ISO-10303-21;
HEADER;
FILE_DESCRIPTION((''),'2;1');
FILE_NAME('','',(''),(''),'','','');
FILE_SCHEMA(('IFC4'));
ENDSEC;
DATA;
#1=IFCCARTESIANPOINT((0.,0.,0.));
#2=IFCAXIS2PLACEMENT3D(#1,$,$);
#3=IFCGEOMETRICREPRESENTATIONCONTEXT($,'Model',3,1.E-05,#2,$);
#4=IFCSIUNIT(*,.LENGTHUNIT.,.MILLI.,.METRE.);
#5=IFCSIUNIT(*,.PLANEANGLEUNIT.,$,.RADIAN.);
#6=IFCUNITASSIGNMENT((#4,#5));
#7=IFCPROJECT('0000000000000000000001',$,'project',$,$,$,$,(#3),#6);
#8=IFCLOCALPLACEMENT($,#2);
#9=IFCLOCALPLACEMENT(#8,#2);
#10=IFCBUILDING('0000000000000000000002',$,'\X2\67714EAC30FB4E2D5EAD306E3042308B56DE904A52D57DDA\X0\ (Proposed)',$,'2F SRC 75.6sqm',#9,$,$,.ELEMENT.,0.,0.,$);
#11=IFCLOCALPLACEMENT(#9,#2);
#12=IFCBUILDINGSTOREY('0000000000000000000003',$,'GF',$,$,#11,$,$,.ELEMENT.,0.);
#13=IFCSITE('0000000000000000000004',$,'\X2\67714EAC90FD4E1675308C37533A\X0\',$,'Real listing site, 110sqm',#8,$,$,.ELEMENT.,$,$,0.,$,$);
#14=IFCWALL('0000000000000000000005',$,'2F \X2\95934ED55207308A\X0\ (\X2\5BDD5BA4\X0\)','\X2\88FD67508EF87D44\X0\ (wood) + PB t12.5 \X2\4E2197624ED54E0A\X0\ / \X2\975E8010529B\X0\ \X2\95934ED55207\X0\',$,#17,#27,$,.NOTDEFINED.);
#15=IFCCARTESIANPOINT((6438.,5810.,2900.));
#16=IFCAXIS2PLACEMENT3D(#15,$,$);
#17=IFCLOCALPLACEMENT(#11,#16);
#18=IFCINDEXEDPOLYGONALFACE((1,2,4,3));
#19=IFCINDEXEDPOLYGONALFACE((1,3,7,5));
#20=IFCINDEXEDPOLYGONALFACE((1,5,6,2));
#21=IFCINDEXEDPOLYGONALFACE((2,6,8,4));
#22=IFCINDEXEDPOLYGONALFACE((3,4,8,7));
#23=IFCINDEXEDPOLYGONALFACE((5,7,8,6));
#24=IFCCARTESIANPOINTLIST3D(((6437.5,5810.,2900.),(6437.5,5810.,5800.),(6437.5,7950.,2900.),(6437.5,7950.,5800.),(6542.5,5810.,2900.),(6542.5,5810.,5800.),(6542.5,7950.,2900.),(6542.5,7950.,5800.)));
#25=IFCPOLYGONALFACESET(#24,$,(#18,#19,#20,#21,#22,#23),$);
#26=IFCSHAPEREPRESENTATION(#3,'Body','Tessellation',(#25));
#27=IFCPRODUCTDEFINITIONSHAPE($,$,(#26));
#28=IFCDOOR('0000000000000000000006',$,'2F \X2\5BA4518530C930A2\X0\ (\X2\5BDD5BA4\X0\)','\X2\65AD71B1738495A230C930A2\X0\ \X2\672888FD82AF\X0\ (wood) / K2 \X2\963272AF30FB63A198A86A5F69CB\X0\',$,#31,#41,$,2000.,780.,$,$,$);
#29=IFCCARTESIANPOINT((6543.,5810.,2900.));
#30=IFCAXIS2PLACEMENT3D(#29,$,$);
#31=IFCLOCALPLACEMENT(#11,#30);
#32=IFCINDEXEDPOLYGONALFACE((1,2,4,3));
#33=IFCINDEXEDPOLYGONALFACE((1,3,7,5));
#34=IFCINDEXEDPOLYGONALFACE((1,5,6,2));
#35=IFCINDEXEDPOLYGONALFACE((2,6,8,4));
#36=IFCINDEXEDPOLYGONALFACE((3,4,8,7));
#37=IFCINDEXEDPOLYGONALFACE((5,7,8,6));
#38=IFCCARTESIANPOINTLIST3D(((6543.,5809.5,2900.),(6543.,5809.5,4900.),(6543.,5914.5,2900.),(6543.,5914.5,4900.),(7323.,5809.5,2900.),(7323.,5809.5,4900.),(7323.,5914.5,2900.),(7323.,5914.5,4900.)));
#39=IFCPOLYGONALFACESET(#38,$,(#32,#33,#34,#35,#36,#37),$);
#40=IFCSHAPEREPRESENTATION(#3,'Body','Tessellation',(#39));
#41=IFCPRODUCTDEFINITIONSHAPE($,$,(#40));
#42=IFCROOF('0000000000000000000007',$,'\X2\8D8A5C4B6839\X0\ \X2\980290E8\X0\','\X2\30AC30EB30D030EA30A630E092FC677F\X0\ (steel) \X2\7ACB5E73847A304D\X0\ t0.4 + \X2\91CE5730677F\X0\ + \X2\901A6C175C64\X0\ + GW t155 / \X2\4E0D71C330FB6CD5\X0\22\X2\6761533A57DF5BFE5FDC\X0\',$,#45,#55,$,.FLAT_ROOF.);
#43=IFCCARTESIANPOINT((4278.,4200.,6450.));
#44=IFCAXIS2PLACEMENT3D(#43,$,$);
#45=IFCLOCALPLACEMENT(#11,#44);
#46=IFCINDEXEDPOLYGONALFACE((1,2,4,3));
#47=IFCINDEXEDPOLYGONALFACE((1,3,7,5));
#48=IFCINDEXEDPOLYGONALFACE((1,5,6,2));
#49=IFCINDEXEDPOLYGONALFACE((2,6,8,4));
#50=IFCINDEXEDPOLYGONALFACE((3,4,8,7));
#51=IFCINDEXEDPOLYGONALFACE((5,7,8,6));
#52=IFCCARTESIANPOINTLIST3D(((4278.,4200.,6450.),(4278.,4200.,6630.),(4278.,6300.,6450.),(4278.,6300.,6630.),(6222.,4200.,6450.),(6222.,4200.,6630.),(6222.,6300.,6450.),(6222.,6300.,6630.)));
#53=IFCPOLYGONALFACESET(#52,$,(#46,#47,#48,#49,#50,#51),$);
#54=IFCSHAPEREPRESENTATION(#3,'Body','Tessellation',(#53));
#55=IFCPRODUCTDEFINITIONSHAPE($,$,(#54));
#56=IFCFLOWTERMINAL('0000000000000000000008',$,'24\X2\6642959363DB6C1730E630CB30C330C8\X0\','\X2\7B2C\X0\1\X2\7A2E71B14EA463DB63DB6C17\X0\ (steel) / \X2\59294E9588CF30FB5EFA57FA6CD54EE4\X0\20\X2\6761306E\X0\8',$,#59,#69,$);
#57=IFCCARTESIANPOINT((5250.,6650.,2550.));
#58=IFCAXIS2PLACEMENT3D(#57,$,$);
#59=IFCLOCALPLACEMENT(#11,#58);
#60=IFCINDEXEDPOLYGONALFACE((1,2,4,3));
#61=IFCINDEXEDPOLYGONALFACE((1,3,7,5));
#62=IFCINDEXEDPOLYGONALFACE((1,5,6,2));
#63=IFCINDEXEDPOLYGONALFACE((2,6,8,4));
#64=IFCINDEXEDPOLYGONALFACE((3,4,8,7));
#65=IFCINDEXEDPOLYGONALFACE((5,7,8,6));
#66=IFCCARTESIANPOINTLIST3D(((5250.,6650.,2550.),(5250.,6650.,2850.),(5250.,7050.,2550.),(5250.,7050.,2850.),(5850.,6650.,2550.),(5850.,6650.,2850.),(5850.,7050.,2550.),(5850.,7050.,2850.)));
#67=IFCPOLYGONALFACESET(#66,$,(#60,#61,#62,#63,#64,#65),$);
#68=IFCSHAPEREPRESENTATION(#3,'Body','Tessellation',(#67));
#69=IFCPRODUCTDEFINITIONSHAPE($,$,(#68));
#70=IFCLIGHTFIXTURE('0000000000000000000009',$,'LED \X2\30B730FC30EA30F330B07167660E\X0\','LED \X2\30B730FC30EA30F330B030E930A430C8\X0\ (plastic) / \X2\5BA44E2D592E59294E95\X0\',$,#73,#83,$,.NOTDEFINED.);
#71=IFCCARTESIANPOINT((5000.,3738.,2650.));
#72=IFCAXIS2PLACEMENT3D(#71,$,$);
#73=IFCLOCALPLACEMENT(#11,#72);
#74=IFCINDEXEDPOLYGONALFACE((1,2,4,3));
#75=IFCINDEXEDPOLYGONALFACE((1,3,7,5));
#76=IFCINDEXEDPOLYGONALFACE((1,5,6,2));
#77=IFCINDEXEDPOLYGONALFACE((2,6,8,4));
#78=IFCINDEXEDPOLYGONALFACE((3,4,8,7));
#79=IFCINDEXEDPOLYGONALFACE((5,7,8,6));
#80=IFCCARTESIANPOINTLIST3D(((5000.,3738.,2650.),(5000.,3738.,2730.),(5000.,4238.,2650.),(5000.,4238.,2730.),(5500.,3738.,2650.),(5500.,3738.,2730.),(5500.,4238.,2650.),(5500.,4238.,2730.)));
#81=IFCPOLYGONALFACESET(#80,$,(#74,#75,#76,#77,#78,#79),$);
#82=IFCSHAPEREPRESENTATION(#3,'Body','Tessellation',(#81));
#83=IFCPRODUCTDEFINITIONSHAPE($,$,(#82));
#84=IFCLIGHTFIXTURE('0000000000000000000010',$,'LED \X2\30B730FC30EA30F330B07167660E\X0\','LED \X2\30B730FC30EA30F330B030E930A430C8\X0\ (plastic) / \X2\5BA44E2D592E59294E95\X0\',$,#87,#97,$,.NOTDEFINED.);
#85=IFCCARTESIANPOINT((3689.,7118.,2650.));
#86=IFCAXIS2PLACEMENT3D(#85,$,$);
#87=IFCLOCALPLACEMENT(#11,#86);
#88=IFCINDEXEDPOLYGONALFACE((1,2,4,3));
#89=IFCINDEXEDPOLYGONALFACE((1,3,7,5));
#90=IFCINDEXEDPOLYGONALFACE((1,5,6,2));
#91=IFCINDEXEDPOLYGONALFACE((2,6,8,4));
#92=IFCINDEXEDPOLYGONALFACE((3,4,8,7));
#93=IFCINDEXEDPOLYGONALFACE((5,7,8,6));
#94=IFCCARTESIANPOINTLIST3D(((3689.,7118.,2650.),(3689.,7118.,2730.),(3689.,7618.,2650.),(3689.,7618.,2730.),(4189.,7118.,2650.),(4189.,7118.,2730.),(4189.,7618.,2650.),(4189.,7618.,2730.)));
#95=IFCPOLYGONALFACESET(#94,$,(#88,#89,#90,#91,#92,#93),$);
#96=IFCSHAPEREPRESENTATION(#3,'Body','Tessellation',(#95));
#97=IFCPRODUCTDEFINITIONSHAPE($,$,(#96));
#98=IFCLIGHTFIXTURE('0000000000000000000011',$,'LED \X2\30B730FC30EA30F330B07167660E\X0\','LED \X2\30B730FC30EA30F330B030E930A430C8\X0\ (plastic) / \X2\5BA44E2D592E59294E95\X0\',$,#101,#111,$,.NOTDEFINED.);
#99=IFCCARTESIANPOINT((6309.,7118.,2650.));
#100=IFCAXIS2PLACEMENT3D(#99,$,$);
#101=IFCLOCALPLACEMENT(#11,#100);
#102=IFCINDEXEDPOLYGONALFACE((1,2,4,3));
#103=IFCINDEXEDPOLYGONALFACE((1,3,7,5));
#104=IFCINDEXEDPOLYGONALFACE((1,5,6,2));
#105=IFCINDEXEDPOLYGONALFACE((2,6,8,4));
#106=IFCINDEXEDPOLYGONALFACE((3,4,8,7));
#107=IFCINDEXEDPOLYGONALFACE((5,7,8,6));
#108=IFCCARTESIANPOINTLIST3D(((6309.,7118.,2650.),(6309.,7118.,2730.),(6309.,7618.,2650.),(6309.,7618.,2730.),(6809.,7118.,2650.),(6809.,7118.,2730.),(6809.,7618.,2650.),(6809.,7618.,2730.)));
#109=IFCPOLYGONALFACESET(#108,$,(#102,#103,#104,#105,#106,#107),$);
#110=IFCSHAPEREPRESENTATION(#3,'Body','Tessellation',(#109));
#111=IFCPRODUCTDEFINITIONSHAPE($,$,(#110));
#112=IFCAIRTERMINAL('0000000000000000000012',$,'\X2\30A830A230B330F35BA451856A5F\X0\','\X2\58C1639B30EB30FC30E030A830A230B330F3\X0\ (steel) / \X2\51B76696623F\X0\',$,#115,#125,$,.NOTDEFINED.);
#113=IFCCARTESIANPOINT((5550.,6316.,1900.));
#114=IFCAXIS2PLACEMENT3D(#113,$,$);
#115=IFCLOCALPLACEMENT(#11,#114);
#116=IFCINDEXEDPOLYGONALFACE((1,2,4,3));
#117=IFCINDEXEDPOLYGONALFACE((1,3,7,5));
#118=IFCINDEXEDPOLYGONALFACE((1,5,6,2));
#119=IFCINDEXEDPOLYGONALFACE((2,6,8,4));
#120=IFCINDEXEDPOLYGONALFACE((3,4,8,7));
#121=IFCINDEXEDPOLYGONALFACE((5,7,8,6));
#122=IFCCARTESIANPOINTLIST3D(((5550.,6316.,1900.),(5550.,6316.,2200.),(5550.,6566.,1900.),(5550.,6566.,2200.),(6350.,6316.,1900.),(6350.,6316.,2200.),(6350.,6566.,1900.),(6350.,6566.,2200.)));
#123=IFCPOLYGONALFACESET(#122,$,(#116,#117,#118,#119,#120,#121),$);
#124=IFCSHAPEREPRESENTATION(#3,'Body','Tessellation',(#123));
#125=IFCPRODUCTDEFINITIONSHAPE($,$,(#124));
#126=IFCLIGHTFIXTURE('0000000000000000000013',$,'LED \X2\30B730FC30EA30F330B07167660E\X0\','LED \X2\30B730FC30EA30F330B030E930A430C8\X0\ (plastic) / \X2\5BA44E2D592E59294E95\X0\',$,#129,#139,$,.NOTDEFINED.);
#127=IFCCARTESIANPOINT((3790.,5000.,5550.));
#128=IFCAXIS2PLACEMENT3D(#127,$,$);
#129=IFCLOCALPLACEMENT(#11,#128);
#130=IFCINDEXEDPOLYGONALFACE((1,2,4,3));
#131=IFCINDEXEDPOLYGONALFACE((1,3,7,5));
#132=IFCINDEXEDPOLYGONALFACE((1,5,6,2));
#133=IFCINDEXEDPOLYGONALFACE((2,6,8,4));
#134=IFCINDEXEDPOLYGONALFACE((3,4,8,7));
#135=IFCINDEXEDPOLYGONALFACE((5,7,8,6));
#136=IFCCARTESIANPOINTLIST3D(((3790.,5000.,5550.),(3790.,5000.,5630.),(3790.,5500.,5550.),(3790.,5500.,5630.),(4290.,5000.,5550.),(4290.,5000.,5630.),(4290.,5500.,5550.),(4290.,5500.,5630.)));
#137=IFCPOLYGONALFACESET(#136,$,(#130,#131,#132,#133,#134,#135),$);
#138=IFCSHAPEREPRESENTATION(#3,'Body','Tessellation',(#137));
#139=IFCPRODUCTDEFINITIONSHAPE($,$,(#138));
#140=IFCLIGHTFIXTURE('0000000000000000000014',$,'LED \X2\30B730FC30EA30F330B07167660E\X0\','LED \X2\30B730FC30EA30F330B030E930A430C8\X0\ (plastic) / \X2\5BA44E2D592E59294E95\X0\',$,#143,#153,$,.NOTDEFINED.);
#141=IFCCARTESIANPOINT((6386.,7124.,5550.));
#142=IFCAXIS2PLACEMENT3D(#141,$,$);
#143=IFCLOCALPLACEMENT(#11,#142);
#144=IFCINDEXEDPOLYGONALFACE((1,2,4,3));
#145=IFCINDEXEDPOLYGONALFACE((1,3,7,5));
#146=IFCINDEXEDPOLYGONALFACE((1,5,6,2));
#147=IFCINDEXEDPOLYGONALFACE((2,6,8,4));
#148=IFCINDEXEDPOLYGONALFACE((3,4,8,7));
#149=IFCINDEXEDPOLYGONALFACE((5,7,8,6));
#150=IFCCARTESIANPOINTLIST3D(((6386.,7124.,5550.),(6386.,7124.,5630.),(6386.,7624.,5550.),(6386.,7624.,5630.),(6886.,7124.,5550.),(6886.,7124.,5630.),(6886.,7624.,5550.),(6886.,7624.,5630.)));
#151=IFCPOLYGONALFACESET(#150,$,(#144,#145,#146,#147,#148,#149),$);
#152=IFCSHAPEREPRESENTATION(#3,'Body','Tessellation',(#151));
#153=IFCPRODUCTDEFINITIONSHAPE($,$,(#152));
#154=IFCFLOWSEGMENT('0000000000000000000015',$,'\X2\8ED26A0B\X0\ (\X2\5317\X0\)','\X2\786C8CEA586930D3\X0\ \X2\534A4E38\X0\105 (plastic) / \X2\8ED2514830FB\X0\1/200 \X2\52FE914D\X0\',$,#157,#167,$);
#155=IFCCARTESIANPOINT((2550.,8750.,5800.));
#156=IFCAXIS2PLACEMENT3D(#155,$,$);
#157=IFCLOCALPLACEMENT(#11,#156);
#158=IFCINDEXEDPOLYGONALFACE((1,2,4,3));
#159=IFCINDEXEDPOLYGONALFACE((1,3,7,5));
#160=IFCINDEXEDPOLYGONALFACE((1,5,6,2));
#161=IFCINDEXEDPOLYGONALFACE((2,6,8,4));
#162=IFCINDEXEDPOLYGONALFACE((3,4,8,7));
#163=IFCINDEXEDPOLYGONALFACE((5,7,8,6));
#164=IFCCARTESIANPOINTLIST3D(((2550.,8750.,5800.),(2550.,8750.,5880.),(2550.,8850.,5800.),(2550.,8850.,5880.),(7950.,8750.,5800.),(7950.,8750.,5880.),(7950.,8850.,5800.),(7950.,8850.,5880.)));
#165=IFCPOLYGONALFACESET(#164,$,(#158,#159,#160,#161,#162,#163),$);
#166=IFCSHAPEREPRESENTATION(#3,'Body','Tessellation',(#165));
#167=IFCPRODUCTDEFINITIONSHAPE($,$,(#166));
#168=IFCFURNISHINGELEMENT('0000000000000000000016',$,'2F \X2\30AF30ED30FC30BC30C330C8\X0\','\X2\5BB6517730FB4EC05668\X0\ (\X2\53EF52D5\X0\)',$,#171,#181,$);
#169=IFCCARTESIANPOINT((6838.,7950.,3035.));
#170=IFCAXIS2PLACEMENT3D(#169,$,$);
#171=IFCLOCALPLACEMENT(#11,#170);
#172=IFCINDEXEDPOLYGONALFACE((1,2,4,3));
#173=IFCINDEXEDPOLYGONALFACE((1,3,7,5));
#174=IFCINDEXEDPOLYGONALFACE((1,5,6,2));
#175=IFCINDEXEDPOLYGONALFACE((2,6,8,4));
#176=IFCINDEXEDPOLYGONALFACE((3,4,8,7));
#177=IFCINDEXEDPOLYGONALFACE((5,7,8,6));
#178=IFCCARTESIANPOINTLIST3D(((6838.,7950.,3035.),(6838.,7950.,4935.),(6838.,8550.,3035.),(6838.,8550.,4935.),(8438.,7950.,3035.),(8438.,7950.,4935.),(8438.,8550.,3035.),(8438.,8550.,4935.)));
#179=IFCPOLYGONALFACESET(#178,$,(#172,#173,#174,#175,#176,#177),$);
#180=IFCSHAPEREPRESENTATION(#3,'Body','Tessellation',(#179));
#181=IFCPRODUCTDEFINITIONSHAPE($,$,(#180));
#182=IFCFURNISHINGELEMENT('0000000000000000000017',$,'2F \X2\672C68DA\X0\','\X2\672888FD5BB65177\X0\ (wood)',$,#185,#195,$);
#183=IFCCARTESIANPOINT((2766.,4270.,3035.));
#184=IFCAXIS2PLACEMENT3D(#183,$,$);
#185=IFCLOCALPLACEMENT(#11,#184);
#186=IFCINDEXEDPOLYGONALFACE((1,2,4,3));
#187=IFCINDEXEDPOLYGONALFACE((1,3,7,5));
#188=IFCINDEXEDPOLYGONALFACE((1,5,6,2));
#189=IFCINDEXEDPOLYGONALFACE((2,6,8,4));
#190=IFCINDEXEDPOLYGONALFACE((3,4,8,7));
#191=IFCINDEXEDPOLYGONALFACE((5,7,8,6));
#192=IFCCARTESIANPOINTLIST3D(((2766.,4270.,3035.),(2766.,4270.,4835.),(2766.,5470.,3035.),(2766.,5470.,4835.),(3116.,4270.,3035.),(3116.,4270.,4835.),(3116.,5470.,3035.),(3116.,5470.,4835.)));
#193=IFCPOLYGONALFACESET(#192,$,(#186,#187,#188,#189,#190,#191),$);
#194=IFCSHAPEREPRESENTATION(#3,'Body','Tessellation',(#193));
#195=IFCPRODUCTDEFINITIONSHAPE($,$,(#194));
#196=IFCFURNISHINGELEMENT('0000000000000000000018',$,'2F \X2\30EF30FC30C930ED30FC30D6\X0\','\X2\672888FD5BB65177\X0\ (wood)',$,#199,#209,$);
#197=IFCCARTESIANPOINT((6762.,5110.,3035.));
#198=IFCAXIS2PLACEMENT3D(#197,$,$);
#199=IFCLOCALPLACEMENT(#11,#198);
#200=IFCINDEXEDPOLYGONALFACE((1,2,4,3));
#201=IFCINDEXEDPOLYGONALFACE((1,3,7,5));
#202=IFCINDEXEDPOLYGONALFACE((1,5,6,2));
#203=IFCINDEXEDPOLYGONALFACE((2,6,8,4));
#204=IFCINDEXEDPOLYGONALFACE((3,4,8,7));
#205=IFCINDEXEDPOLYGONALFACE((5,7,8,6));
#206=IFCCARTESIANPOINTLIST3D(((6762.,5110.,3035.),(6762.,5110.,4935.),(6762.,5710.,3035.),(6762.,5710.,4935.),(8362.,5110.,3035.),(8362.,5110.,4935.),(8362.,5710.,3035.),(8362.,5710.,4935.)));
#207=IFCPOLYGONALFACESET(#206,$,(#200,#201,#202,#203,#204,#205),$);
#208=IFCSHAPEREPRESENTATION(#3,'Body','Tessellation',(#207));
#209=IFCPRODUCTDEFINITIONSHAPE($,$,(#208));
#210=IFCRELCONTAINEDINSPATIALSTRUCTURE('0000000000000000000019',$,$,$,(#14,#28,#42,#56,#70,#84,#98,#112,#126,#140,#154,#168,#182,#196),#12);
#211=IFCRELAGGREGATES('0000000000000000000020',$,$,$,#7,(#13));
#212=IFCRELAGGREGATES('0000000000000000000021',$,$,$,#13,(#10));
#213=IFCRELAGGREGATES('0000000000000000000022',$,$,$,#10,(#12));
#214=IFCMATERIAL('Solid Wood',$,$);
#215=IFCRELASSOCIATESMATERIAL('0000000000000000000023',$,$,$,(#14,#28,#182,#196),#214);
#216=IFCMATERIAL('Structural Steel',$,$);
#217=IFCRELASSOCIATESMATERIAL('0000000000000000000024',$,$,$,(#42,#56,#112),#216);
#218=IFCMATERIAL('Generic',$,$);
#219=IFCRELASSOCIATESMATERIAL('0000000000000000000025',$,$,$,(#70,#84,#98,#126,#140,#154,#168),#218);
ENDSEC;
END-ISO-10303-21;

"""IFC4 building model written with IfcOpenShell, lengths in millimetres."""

from ifc_helpers import new_model, si_unit, frame, frame_2d, origin, place, context, project, spatial, rectangle, extrude, material, element, save


model = new_model("IFC4")

# Units and contexts
model_context = context("Model", 3, precision=1e-05, world=origin())
ifc_project = project(units=[si_unit("LENGTHUNIT", "METRE", prefix="MILLI"), si_unit("PLANEANGLEUNIT", "RADIAN")], contexts=[model_context])

# Site, building, storey
site_placement = place(None, origin())
site = spatial("IfcSite", under=ifc_project, at=site_placement, Name="東京都世田谷区", ObjectType="Real listing site, 110sqm", CompositionType="ELEMENT", RefElevation=0.0)
building_placement = place(site_placement, origin())
building = spatial("IfcBuilding", under=site, at=building_placement, Name="東京・中庭のある回遊動線 (Proposed)", ObjectType="2F SRC 75.6sqm", CompositionType="ELEMENT", ElevationOfRefHeight=0.0, ElevationOfTerrain=0.0)
storey_placement = place(building_placement, origin())
storey = spatial("IfcBuildingStorey", under=building, at=storey_placement, Name="GF", CompositionType="ELEMENT", Elevation=0.0)

# Shared definitions
ifc_material_1 = material(Name="Solid Wood")

# Wall
wall_1_placement = place(storey_placement, frame((6438.0, 5810.0, 2900.0)))
element("IfcWall", 1, at=wall_1_placement, inside=storey, material=ifc_material_1, Name="2F 間仕切り (寝室)", Description="製材軸組 (wood) + PB t12.5 両面仕上 / 非耐力 間仕切", PredefinedType="NOTDEFINED", context=model_context, shape_type="SweptSolid", body=[
    extrude(rectangle(XDim=105.0, YDim=2140.0, at=frame_2d((52.0, 1070.0))), frame((6438.0, 5810.0, 2900.0)), (0.0, 0.0, 1.0), 2900.0),
])

# Door
door_placement = place(storey_placement, frame((6543.0, 5810.0, 2900.0)))
element("IfcDoor", 2, at=door_placement, inside=storey, material=ifc_material_1, Name="2F 室内ドア (寝室)", Description="断熱玄関ドア 木製芯 (wood) / K2 防犯・採風機構", OverallHeight=2000.0, OverallWidth=780.0, context=model_context, shape_type="SweptSolid", body=[
    extrude(rectangle(XDim=780.0, YDim=105.0, at=frame_2d((390.0, 52.0))), frame((6543.0, 5810.0, 2900.0)), (0.0, 0.0, 1.0), 2000.0),
])

# Roof
ifc_material_2 = material(Name="Structural Steel")
roof_placement = place(storey_placement, frame((4278.0, 4200.0, 6450.0)))
element("IfcRoof", 3, at=roof_placement, inside=storey, material=ifc_material_2, Name="越屋根 頂部", Description="ガルバリウム鋼板 (steel) 立平葺き t0.4 + 野地板 + 通気層 + GW t155 / 不燃・法22条区域対応", PredefinedType="FLAT_ROOF", context=model_context, shape_type="SweptSolid", body=[
    extrude(rectangle(XDim=1944.0, YDim=2100.0, at=frame_2d((972.0, 1050.0))), frame((4278.0, 4200.0, 6450.0)), (0.0, 0.0, 1.0), 180.0),
])

# Flow terminal
flow_terminal_placement = place(storey_placement, frame((5250.0, 6650.0, 2550.0)))
element("IfcFlowTerminal", 4, at=flow_terminal_placement, inside=storey, material=ifc_material_2, Name="24時間換気ユニット", Description="第1種熱交換換気 (steel) / 天井裏・建基法令20条の8", context=model_context, shape_type="SweptSolid", body=[
    extrude(rectangle(XDim=600.0, YDim=400.0, at=frame_2d((300.0, 200.0))), frame((5250.0, 6650.0, 2550.0)), (0.0, 0.0, 1.0), 300.0),
])

# Light fixtures
ifc_material_3 = material(Name="Generic")
light_fixture_1_placement = place(storey_placement, frame((5000.0, 3738.0, 2650.0)))
element("IfcLightFixture", 5, at=light_fixture_1_placement, inside=storey, material=ifc_material_3, Name="LED シーリング照明", Description="LED シーリングライト (plastic) / 室中央天井", PredefinedType="NOTDEFINED", context=model_context, shape_type="SweptSolid", body=[
    extrude(rectangle(XDim=500.0, YDim=500.0, at=frame_2d((250.0, 250.0))), frame((5000.0, 3738.0, 2650.0)), (0.0, 0.0, 1.0), 80.0),
])
light_fixture_2_placement = place(storey_placement, frame((3689.0, 7118.0, 2650.0)))
element("IfcLightFixture", 6, at=light_fixture_2_placement, inside=storey, material=ifc_material_3, Name="LED シーリング照明", Description="LED シーリングライト (plastic) / 室中央天井", PredefinedType="NOTDEFINED", context=model_context, shape_type="SweptSolid", body=[
    extrude(rectangle(XDim=500.0, YDim=500.0, at=frame_2d((250.0, 250.0))), frame((3689.0, 7118.0, 2650.0)), (0.0, 0.0, 1.0), 80.0),
])
light_fixture_3_placement = place(storey_placement, frame((6309.0, 7118.0, 2650.0)))
element("IfcLightFixture", 7, at=light_fixture_3_placement, inside=storey, material=ifc_material_3, Name="LED シーリング照明", Description="LED シーリングライト (plastic) / 室中央天井", PredefinedType="NOTDEFINED", context=model_context, shape_type="SweptSolid", body=[
    extrude(rectangle(XDim=500.0, YDim=500.0, at=frame_2d((250.0, 250.0))), frame((6309.0, 7118.0, 2650.0)), (0.0, 0.0, 1.0), 80.0),
])

# Air terminal
air_terminal_placement = place(storey_placement, frame((5550.0, 6316.0, 1900.0)))
element("IfcAirTerminal", 8, at=air_terminal_placement, inside=storey, material=ifc_material_2, Name="エアコン室内機", Description="壁掛ルームエアコン (steel) / 冷暖房", PredefinedType="NOTDEFINED", context=model_context, shape_type="SweptSolid", body=[
    extrude(rectangle(XDim=800.0, YDim=250.0, at=frame_2d((400.0, 125.0))), frame((5550.0, 6316.0, 1900.0)), (0.0, 0.0, 1.0), 300.0),
])

# Light fixtures
light_fixture_4_placement = place(storey_placement, frame((3790.0, 5000.0, 5550.0)))
element("IfcLightFixture", 9, at=light_fixture_4_placement, inside=storey, material=ifc_material_3, Name="LED シーリング照明", Description="LED シーリングライト (plastic) / 室中央天井", PredefinedType="NOTDEFINED", context=model_context, shape_type="SweptSolid", body=[
    extrude(rectangle(XDim=500.0, YDim=500.0, at=frame_2d((250.0, 250.0))), frame((3790.0, 5000.0, 5550.0)), (0.0, 0.0, 1.0), 80.0),
])
light_fixture_5_placement = place(storey_placement, frame((6386.0, 7124.0, 5550.0)))
element("IfcLightFixture", 10, at=light_fixture_5_placement, inside=storey, material=ifc_material_3, Name="LED シーリング照明", Description="LED シーリングライト (plastic) / 室中央天井", PredefinedType="NOTDEFINED", context=model_context, shape_type="SweptSolid", body=[
    extrude(rectangle(XDim=500.0, YDim=500.0, at=frame_2d((250.0, 250.0))), frame((6386.0, 7124.0, 5550.0)), (0.0, 0.0, 1.0), 80.0),
])

# Flow segment
flow_segment_placement = place(storey_placement, frame((2550.0, 8750.0, 5800.0)))
element("IfcFlowSegment", 11, at=flow_segment_placement, inside=storey, material=ifc_material_3, Name="軒樋 (北)", Description="硬質塩ビ 半丸105 (plastic) / 軒先・1/200 勾配", context=model_context, shape_type="SweptSolid", body=[
    extrude(rectangle(XDim=5400.0, YDim=100.0, at=frame_2d((2700.0, 50.0))), frame((2550.0, 8750.0, 5800.0)), (0.0, 0.0, 1.0), 80.0),
])

# Furnishing elements
furnishing_1_placement = place(storey_placement, frame((6838.0, 7950.0, 3035.0)))
element("IfcFurnishingElement", 12, at=furnishing_1_placement, inside=storey, material=ifc_material_3, Name="2F クローゼット", Description="家具・什器 (可動)", context=model_context, shape_type="SweptSolid", body=[
    extrude(rectangle(XDim=1600.0, YDim=600.0, at=frame_2d((800.0, 300.0))), frame((6838.0, 7950.0, 3035.0)), (0.0, 0.0, 1.0), 1900.0),
])
furnishing_2_placement = place(storey_placement, frame((2766.0, 4270.0, 3035.0)))
element("IfcFurnishingElement", 13, at=furnishing_2_placement, inside=storey, material=ifc_material_1, Name="2F 本棚", Description="木製家具 (wood)", context=model_context, shape_type="SweptSolid", body=[
    extrude(rectangle(XDim=350.0, YDim=1200.0, at=frame_2d((175.0, 600.0))), frame((2766.0, 4270.0, 3035.0)), (0.0, 0.0, 1.0), 1800.0),
])
furnishing_3_placement = place(storey_placement, frame((6762.0, 5110.0, 3035.0)))
element("IfcFurnishingElement", 14, at=furnishing_3_placement, inside=storey, material=ifc_material_1, Name="2F ワードローブ", Description="木製家具 (wood)", context=model_context, shape_type="SweptSolid", body=[
    extrude(rectangle(XDim=1600.0, YDim=600.0, at=frame_2d((800.0, 300.0))), frame((6762.0, 5110.0, 3035.0)), (0.0, 0.0, 1.0), 1900.0),
])

save(model, "model.ifc")
